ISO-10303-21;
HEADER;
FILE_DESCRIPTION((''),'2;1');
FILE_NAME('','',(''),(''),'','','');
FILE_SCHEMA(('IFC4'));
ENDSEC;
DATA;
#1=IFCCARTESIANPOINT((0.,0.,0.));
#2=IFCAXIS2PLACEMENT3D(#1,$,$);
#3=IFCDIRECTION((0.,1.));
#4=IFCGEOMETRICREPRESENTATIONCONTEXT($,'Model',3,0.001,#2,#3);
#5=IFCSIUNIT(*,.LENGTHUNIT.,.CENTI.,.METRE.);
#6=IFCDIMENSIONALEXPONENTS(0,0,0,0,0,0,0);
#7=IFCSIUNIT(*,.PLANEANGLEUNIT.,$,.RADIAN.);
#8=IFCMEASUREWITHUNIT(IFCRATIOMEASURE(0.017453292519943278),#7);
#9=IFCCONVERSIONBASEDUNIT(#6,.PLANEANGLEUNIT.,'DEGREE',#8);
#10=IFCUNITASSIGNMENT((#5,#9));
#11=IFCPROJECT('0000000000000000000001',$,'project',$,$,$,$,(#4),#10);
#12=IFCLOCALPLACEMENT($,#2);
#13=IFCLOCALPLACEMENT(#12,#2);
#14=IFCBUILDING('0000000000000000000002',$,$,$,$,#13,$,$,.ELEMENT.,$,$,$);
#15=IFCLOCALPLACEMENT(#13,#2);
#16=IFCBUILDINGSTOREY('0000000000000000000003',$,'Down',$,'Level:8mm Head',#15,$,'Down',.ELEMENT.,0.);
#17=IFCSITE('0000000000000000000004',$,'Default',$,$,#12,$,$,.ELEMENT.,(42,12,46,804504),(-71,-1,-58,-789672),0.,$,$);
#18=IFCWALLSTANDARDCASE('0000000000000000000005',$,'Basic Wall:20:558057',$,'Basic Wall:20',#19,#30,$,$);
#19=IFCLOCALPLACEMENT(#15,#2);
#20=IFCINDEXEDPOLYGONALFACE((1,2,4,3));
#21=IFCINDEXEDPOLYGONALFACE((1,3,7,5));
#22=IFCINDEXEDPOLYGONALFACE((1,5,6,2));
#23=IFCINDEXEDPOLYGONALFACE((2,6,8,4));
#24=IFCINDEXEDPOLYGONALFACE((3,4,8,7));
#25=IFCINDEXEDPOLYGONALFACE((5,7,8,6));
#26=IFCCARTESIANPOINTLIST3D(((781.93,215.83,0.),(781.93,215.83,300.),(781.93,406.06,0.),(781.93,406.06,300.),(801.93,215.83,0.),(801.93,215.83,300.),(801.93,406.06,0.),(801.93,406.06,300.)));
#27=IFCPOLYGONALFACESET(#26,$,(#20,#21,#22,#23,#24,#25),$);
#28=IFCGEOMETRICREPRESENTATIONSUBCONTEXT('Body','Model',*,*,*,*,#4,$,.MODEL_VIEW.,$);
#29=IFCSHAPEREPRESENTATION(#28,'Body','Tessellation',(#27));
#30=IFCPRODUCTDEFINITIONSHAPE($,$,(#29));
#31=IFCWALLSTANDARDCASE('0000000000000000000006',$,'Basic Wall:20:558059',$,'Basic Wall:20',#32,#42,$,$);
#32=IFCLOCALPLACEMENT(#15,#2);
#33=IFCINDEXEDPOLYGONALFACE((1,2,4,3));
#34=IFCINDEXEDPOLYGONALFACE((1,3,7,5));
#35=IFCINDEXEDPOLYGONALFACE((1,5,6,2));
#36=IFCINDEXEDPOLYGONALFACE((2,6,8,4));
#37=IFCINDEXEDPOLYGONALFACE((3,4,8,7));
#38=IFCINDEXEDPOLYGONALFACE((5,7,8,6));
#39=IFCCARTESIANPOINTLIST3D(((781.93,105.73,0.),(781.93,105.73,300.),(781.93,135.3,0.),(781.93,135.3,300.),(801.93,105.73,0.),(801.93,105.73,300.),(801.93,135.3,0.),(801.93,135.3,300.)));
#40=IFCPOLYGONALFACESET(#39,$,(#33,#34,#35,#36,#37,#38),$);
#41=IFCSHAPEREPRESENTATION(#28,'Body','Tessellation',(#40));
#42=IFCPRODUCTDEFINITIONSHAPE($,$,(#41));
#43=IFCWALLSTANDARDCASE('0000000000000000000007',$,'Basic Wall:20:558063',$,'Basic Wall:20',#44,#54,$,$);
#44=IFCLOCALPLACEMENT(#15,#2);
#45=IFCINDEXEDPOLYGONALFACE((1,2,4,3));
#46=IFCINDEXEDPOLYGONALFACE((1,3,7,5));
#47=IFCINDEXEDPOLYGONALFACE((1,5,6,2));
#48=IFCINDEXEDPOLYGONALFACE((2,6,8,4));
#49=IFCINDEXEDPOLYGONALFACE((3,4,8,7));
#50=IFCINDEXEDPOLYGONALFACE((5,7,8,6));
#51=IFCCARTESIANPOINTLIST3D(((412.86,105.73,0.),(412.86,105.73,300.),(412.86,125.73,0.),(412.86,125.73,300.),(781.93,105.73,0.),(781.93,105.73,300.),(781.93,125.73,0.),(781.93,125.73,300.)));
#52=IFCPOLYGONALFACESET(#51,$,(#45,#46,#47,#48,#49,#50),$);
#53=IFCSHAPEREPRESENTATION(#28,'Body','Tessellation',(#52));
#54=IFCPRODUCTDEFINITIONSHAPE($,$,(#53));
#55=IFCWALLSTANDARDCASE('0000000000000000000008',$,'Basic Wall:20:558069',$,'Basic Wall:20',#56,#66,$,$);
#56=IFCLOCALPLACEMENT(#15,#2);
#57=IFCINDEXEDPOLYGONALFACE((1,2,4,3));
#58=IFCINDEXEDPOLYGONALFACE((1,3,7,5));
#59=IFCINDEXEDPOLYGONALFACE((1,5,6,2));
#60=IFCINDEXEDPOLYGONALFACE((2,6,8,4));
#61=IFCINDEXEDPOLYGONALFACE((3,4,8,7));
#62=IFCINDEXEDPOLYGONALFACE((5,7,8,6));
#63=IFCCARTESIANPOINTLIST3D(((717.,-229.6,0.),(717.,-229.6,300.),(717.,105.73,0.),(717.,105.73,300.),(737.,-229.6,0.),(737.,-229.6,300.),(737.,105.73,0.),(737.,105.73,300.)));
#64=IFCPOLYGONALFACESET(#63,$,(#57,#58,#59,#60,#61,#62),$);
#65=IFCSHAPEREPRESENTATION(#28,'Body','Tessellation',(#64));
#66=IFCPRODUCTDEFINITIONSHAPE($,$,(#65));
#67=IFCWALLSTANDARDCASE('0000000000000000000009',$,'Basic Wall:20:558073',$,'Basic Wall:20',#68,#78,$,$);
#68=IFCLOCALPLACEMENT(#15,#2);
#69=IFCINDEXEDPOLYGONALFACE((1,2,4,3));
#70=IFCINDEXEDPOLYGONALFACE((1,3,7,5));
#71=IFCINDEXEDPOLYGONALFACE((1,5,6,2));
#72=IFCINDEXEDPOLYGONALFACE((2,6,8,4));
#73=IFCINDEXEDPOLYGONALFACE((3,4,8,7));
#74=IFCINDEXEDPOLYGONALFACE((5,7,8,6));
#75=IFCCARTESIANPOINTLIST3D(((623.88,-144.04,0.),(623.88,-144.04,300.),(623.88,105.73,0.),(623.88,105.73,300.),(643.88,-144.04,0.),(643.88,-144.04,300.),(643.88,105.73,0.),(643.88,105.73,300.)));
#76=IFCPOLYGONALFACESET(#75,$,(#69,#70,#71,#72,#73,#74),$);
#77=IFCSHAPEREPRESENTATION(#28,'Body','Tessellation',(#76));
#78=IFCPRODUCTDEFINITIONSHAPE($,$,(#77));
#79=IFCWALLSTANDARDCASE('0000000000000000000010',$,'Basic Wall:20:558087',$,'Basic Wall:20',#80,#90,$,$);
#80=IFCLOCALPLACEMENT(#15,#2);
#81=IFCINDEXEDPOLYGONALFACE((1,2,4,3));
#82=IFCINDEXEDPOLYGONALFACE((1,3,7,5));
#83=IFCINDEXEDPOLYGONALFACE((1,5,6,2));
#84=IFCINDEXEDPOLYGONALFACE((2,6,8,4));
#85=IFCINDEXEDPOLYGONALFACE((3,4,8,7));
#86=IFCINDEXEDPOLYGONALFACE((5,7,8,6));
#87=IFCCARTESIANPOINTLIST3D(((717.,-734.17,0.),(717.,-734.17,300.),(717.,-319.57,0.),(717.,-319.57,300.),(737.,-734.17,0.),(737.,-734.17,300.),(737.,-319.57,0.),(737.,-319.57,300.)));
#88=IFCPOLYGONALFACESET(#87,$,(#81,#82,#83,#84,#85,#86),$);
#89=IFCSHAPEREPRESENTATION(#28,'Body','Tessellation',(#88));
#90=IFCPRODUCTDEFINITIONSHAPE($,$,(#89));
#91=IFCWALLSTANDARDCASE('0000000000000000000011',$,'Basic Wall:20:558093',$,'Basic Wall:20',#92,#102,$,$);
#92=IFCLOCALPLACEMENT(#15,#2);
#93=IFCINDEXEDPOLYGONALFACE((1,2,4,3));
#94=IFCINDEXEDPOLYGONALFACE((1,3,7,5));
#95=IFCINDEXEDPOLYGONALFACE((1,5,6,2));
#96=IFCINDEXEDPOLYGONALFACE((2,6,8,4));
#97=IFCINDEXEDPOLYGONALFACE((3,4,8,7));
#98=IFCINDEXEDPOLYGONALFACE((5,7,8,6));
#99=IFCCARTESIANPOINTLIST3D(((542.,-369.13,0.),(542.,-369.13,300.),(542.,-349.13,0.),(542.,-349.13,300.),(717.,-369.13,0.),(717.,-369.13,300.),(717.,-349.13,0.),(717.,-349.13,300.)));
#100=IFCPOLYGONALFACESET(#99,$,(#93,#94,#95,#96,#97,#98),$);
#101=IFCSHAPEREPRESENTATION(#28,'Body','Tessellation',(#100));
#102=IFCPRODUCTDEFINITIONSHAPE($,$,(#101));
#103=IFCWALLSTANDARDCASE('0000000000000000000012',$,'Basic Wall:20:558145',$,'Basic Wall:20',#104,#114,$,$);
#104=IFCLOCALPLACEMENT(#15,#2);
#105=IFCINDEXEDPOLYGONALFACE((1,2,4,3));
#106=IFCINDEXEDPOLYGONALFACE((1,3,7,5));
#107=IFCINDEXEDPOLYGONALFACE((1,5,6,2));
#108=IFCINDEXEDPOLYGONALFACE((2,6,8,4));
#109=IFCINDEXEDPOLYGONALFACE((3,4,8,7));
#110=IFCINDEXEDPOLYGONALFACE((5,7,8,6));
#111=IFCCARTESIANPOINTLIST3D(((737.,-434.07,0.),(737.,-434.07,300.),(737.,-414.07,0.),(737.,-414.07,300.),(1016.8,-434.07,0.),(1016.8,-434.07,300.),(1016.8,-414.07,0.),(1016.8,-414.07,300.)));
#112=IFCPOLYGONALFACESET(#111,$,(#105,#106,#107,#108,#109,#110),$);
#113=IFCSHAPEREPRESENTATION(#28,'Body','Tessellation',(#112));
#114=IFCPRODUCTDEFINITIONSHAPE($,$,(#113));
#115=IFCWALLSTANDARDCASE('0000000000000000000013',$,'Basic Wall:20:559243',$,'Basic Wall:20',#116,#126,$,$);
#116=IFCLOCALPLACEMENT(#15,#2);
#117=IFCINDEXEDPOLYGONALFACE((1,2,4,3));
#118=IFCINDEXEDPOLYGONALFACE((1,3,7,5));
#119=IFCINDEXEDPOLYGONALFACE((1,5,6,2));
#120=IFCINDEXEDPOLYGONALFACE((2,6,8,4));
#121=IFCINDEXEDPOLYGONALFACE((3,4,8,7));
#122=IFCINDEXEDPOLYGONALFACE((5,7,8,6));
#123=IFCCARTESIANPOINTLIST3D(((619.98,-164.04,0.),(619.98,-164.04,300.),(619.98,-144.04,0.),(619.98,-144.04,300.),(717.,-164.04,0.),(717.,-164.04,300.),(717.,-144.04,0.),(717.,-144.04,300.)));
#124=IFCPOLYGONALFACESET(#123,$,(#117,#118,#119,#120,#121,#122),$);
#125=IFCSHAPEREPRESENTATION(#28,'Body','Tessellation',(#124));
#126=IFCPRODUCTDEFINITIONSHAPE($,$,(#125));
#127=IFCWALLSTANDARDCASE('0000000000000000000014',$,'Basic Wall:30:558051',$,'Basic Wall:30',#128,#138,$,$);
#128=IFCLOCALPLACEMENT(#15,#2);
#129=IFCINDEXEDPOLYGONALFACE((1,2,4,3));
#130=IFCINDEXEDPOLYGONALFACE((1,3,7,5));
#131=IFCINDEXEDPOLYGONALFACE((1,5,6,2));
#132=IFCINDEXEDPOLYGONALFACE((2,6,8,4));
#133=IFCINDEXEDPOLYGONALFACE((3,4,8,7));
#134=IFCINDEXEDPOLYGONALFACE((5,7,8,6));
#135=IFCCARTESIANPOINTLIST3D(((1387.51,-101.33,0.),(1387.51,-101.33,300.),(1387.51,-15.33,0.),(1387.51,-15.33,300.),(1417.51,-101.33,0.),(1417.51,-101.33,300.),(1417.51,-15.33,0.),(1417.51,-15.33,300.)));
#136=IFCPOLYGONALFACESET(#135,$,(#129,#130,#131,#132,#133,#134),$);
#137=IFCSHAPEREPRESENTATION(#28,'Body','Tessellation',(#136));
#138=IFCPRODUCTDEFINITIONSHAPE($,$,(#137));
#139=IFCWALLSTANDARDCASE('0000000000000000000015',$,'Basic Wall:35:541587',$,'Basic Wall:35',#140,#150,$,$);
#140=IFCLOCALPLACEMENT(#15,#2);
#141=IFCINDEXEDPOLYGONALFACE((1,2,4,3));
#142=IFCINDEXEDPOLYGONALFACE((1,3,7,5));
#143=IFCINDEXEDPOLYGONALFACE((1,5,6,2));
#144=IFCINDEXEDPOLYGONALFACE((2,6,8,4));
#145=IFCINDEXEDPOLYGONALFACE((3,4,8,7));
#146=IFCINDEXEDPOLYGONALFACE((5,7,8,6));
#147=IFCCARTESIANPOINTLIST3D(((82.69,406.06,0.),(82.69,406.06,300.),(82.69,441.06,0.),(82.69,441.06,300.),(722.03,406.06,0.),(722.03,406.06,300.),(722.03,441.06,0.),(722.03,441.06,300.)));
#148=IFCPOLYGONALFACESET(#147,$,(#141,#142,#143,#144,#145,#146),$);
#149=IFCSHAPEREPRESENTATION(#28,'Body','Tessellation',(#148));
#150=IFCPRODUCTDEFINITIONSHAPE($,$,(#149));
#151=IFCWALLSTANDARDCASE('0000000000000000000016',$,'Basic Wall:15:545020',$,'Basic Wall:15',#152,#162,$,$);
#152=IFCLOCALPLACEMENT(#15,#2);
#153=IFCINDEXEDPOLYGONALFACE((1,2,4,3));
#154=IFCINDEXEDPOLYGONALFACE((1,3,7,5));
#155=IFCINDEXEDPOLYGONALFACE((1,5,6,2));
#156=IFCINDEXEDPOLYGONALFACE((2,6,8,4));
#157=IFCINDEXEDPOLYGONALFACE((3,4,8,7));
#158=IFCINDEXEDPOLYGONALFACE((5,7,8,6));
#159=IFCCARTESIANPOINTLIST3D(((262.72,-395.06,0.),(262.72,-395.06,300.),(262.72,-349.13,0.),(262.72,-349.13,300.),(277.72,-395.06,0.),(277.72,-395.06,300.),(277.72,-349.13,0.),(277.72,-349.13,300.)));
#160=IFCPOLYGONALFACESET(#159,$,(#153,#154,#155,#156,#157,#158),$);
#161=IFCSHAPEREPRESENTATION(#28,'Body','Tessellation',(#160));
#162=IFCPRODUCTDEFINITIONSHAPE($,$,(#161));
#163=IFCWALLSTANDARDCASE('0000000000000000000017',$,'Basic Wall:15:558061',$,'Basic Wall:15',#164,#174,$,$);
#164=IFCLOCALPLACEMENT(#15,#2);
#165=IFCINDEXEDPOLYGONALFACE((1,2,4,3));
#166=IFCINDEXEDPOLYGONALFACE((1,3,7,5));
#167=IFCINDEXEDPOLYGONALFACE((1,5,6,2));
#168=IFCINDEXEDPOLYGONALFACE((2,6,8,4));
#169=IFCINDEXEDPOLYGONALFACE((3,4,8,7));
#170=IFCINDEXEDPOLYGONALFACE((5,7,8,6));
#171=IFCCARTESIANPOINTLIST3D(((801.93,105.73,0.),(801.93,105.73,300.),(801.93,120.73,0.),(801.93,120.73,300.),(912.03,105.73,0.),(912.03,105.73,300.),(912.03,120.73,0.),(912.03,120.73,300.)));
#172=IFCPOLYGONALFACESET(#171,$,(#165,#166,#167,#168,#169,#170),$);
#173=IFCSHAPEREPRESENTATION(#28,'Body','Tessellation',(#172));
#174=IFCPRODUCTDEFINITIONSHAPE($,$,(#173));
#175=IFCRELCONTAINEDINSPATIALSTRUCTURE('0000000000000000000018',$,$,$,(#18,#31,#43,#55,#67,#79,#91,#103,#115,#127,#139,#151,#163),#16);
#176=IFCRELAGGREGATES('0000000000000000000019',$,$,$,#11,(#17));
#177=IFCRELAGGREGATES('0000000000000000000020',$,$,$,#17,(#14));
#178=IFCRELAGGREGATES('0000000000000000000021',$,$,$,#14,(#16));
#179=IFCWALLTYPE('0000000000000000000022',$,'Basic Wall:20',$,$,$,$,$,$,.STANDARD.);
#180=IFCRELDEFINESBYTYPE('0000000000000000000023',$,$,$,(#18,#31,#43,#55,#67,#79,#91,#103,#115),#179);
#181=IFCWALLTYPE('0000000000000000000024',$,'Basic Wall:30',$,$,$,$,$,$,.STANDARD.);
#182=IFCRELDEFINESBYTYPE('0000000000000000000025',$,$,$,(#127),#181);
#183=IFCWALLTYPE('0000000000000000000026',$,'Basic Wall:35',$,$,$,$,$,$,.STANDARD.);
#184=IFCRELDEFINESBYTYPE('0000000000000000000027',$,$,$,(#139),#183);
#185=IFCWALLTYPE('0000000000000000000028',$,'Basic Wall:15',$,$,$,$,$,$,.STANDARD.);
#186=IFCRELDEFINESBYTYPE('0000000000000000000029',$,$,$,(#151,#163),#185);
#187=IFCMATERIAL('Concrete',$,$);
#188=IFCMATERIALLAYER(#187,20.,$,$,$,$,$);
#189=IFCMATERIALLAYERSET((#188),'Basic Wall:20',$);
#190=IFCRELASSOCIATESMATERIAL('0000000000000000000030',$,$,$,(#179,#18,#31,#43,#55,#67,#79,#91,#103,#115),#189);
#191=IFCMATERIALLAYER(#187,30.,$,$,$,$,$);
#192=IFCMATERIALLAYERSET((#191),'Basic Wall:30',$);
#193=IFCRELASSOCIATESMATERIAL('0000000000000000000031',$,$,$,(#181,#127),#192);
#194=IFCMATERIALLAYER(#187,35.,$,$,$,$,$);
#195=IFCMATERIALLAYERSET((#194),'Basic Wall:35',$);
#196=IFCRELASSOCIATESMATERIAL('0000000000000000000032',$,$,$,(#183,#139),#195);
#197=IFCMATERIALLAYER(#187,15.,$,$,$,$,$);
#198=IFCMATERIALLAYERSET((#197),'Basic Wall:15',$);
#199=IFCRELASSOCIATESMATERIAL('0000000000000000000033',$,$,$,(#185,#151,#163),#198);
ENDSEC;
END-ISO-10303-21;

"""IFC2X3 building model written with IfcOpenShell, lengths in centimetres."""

from ifc_helpers import new_model, entity, si_unit, converted_unit, direction, frame, frame_2d, origin, place, context, subcontext, project, spatial, rectangle, extrude, material, layer, layer_set, layer_usage, type_object, element, save


model = new_model("IFC2X3")

# Units and contexts
model_context = context("Model", 3, precision=0.001, world=origin(), true_north=direction((0.0, 1.0)))
body_context = subcontext(model_context, "Body", "Model", "MODEL_VIEW")
ifc_project = project(units=[si_unit("LENGTHUNIT", "METRE", prefix="CENTI"), converted_unit("PLANEANGLEUNIT", "DEGREE", entity("IfcRatioMeasure", 0.017453292519943278), si_unit("PLANEANGLEUNIT", "RADIAN"), dimensions=[0, 0, 0, 0, 0, 0, 0])], contexts=[model_context])

# Site, building, storey
site_placement = place(None, origin())
site = spatial("IfcSite", under=ifc_project, at=site_placement, Name="Default", CompositionType="ELEMENT", RefLatitude=(42, 12, 46, 804504), RefLongitude=(-71, -1, -58, -789672), RefElevation=0.0)
building_placement = place(site_placement, origin())
building = spatial("IfcBuilding", under=site, at=building_placement, CompositionType="ELEMENT")
storey_placement = place(building_placement, origin())
storey = spatial("IfcBuildingStorey", under=building, at=storey_placement, Name="Down", ObjectType="Level:8mm Head", LongName="Down", CompositionType="ELEMENT", Elevation=0.0)

# Walls
ifc_material = material(Name="Concrete")
ifc_layer_1 = layer(ifc_material, 20.0)
ifc_layer_set_1 = layer_set([ifc_layer_1], Name="Basic Wall:20")
wall_type_1 = type_object("IfcWallType", Name="Basic Wall:20", PredefinedType="STANDARD", material=ifc_layer_set_1)
ifc_layer_usage_1 = layer_usage(ifc_layer_set_1, "AXIS2", "NEGATIVE", 10.0)
wall_1_placement = place(storey_placement, frame((791.93, 406.06, 0.0), z_axis=(0.0, 0.0, 1.0), x_axis=(0.0, -1.0, 0.0)))
element("IfcWallStandardCase", 1, at=wall_1_placement, inside=storey, type_object=wall_type_1, material=ifc_layer_usage_1, Name="Basic Wall:20:558057", ObjectType="Basic Wall:20", context=body_context, shape_type="SweptSolid", body=[
    extrude(rectangle(XDim=190.23, YDim=20.0, at=frame_2d((95.12, 0.0), x_axis=(-1.0, 0.0))), origin(), (0.0, 0.0, 1.0), 300.0),
])
ifc_layer_usage_2 = layer_usage(ifc_layer_set_1, "AXIS2", "NEGATIVE", 10.0)
wall_2_placement = place(storey_placement, frame((791.93, 135.3, 0.0), z_axis=(0.0, 0.0, 1.0), x_axis=(0.0, -1.0, 0.0)))
element("IfcWallStandardCase", 2, at=wall_2_placement, inside=storey, type_object=wall_type_1, material=ifc_layer_usage_2, Name="Basic Wall:20:558059", ObjectType="Basic Wall:20", context=body_context, shape_type="SweptSolid", body=[
    extrude(rectangle(XDim=29.57, YDim=20.0, at=frame_2d((14.78, 0.0), x_axis=(-1.0, 0.0))), origin(), (0.0, 0.0, 1.0), 300.0),
])
ifc_layer_usage_3 = layer_usage(ifc_layer_set_1, "AXIS2", "NEGATIVE", 10.0)
wall_3_placement = place(storey_placement, frame((781.93, 115.73, 0.0), z_axis=(0.0, 0.0, 1.0), x_axis=(-1.0, 0.0, 0.0)))
element("IfcWallStandardCase", 3, at=wall_3_placement, inside=storey, type_object=wall_type_1, material=ifc_layer_usage_3, Name="Basic Wall:20:558063", ObjectType="Basic Wall:20", context=body_context, shape_type="SweptSolid", body=[
    extrude(rectangle(XDim=369.07, YDim=20.0, at=frame_2d((184.54, 0.0), x_axis=(-1.0, 0.0))), origin(), (0.0, 0.0, 1.0), 300.0),
])
ifc_layer_usage_4 = layer_usage(ifc_layer_set_1, "AXIS2", "NEGATIVE", 10.0)
wall_4_placement = place(storey_placement, frame((727.0, 105.73, 0.0), z_axis=(0.0, 0.0, 1.0), x_axis=(0.0, -1.0, 0.0)))
element("IfcWallStandardCase", 4, at=wall_4_placement, inside=storey, type_object=wall_type_1, material=ifc_layer_usage_4, Name="Basic Wall:20:558069", ObjectType="Basic Wall:20", context=body_context, shape_type="SweptSolid", body=[
    extrude(rectangle(XDim=335.33, YDim=20.0, at=frame_2d((167.67, 0.0), x_axis=(-1.0, 0.0))), origin(), (0.0, 0.0, 1.0), 300.0),
])
ifc_layer_usage_5 = layer_usage(ifc_layer_set_1, "AXIS2", "NEGATIVE", 10.0)
wall_5_placement = place(storey_placement, frame((633.88, -144.04, 0.0), z_axis=(0.0, 0.0, 1.0), x_axis=(0.0, 1.0, 0.0)))
element("IfcWallStandardCase", 5, at=wall_5_placement, inside=storey, type_object=wall_type_1, material=ifc_layer_usage_5, Name="Basic Wall:20:558073", ObjectType="Basic Wall:20", context=body_context, shape_type="SweptSolid", body=[
    extrude(rectangle(XDim=249.77, YDim=20.0, at=frame_2d((124.88, 0.0), x_axis=(-1.0, 0.0))), origin(), (0.0, 0.0, 1.0), 300.0),
])
ifc_layer_usage_6 = layer_usage(ifc_layer_set_1, "AXIS2", "POSITIVE", -10.0)
wall_6_placement = place(storey_placement, frame((727.0, -319.57, 0.0), z_axis=(0.0, 0.0, 1.0), x_axis=(0.0, -1.0, 0.0)))
element("IfcWallStandardCase", 6, at=wall_6_placement, inside=storey, type_object=wall_type_1, material=ifc_layer_usage_6, Name="Basic Wall:20:558087", ObjectType="Basic Wall:20", context=body_context, shape_type="SweptSolid", body=[
    extrude(rectangle(XDim=414.6, YDim=20.0, at=frame_2d((207.3, 0.0), x_axis=(-1.0, 0.0))), origin(), (0.0, 0.0, 1.0), 300.0),
])
ifc_layer_usage_7 = layer_usage(ifc_layer_set_1, "AXIS2", "NEGATIVE", 10.0)
wall_7_placement = place(storey_placement, frame((542.0, -359.13, 0.0)))
element("IfcWallStandardCase", 7, at=wall_7_placement, inside=storey, type_object=wall_type_1, material=ifc_layer_usage_7, Name="Basic Wall:20:558093", ObjectType="Basic Wall:20", context=body_context, shape_type="SweptSolid", body=[
    extrude(rectangle(XDim=175.0, YDim=20.0, at=frame_2d((87.5, 0.0), x_axis=(-1.0, 0.0))), origin(), (0.0, 0.0, 1.0), 300.0),
])
ifc_layer_usage_8 = layer_usage(ifc_layer_set_1, "AXIS2", "NEGATIVE", 10.0)
wall_8_placement = place(storey_placement, frame((1016.8, -424.07, 0.0), z_axis=(0.0, 0.0, 1.0), x_axis=(-1.0, 0.0, 0.0)))
element("IfcWallStandardCase", 8, at=wall_8_placement, inside=storey, type_object=wall_type_1, material=ifc_layer_usage_8, Name="Basic Wall:20:558145", ObjectType="Basic Wall:20", context=body_context, shape_type="SweptSolid", body=[
    extrude(rectangle(XDim=279.8, YDim=20.0, at=frame_2d((139.9, 0.0), x_axis=(-1.0, 0.0))), origin(), (0.0, 0.0, 1.0), 300.0),
])
ifc_layer_usage_9 = layer_usage(ifc_layer_set_1, "AXIS2", "NEGATIVE", 10.0)
wall_9_placement = place(storey_placement, frame((619.98, -154.04, 0.0)))
element("IfcWallStandardCase", 9, at=wall_9_placement, inside=storey, type_object=wall_type_1, material=ifc_layer_usage_9, Name="Basic Wall:20:559243", ObjectType="Basic Wall:20", context=body_context, shape_type="SweptSolid", body=[
    extrude(rectangle(XDim=97.02, YDim=20.0, at=frame_2d((48.51, 0.0), x_axis=(-1.0, 0.0))), origin(), (0.0, 0.0, 1.0), 300.0),
])
ifc_layer_2 = layer(ifc_material, 30.0)
ifc_layer_set_2 = layer_set([ifc_layer_2], Name="Basic Wall:30")
ifc_layer_usage_10 = layer_usage(ifc_layer_set_2, "AXIS2", "NEGATIVE", 15.0)
wall_type_2 = type_object("IfcWallType", Name="Basic Wall:30", PredefinedType="STANDARD", material=ifc_layer_set_2)
wall_10_placement = place(storey_placement, frame((1402.51, -15.33, 0.0), z_axis=(0.0, 0.0, 1.0), x_axis=(0.0, -1.0, 0.0)))
element("IfcWallStandardCase", 10, at=wall_10_placement, inside=storey, type_object=wall_type_2, material=ifc_layer_usage_10, Name="Basic Wall:30:558051", ObjectType="Basic Wall:30", context=body_context, shape_type="SweptSolid", body=[
    extrude(rectangle(XDim=86.0, YDim=30.0, at=frame_2d((43.0, 0.0), x_axis=(-1.0, 0.0))), origin(), (0.0, 0.0, 1.0), 300.0),
])
ifc_layer_3 = layer(ifc_material, 35.0)
ifc_layer_set_3 = layer_set([ifc_layer_3], Name="Basic Wall:35")
ifc_layer_usage_11 = layer_usage(ifc_layer_set_3, "AXIS2", "POSITIVE", -17.5)
wall_type_3 = type_object("IfcWallType", Name="Basic Wall:35", PredefinedType="STANDARD", material=ifc_layer_set_3)
wall_11_placement = place(storey_placement, frame((722.03, 423.56, 0.0), z_axis=(0.0, 0.0, 1.0), x_axis=(-1.0, 0.0, 0.0)))
element("IfcWallStandardCase", 11, at=wall_11_placement, inside=storey, type_object=wall_type_3, material=ifc_layer_usage_11, Name="Basic Wall:35:541587", ObjectType="Basic Wall:35", context=body_context, shape_type="SweptSolid", body=[
    extrude(rectangle(XDim=639.34, YDim=35.0, at=frame_2d((319.67, 0.0), x_axis=(-1.0, 0.0))), origin(), (0.0, 0.0, 1.0), 300.0),
])
ifc_layer_4 = layer(ifc_material, 15.0)
ifc_layer_set_4 = layer_set([ifc_layer_4], Name="Basic Wall:15")
ifc_layer_usage_12 = layer_usage(ifc_layer_set_4, "AXIS2", "POSITIVE", -7.5)
wall_type_4 = type_object("IfcWallType", Name="Basic Wall:15", PredefinedType="STANDARD", material=ifc_layer_set_4)
wall_12_placement = place(storey_placement, frame((270.22, -395.06, 0.0), z_axis=(0.0, 0.0, 1.0), x_axis=(0.0, 1.0, 0.0)))
element("IfcWallStandardCase", 12, at=wall_12_placement, inside=storey, type_object=wall_type_4, material=ifc_layer_usage_12, Name="Basic Wall:15:545020", ObjectType="Basic Wall:15", context=body_context, shape_type="SweptSolid", body=[
    extrude(rectangle(XDim=45.93, YDim=15.0, at=frame_2d((22.96, 0.0), x_axis=(-1.0, 0.0))), origin(), (0.0, 0.0, 1.0), 300.0),
])
ifc_layer_usage_13 = layer_usage(ifc_layer_set_4, "AXIS2", "POSITIVE", -7.5)
wall_13_placement = place(storey_placement, frame((801.93, 113.23, 0.0)))
element("IfcWallStandardCase", 13, at=wall_13_placement, inside=storey, type_object=wall_type_4, material=ifc_layer_usage_13, Name="Basic Wall:15:558061", ObjectType="Basic Wall:15", context=body_context, shape_type="SweptSolid", body=[
    extrude(rectangle(XDim=110.1, YDim=15.0, at=frame_2d((55.05, 0.0), x_axis=(-1.0, 0.0))), origin(), (0.0, 0.0, 1.0), 300.0),
])

save(model, "model.ifc")
